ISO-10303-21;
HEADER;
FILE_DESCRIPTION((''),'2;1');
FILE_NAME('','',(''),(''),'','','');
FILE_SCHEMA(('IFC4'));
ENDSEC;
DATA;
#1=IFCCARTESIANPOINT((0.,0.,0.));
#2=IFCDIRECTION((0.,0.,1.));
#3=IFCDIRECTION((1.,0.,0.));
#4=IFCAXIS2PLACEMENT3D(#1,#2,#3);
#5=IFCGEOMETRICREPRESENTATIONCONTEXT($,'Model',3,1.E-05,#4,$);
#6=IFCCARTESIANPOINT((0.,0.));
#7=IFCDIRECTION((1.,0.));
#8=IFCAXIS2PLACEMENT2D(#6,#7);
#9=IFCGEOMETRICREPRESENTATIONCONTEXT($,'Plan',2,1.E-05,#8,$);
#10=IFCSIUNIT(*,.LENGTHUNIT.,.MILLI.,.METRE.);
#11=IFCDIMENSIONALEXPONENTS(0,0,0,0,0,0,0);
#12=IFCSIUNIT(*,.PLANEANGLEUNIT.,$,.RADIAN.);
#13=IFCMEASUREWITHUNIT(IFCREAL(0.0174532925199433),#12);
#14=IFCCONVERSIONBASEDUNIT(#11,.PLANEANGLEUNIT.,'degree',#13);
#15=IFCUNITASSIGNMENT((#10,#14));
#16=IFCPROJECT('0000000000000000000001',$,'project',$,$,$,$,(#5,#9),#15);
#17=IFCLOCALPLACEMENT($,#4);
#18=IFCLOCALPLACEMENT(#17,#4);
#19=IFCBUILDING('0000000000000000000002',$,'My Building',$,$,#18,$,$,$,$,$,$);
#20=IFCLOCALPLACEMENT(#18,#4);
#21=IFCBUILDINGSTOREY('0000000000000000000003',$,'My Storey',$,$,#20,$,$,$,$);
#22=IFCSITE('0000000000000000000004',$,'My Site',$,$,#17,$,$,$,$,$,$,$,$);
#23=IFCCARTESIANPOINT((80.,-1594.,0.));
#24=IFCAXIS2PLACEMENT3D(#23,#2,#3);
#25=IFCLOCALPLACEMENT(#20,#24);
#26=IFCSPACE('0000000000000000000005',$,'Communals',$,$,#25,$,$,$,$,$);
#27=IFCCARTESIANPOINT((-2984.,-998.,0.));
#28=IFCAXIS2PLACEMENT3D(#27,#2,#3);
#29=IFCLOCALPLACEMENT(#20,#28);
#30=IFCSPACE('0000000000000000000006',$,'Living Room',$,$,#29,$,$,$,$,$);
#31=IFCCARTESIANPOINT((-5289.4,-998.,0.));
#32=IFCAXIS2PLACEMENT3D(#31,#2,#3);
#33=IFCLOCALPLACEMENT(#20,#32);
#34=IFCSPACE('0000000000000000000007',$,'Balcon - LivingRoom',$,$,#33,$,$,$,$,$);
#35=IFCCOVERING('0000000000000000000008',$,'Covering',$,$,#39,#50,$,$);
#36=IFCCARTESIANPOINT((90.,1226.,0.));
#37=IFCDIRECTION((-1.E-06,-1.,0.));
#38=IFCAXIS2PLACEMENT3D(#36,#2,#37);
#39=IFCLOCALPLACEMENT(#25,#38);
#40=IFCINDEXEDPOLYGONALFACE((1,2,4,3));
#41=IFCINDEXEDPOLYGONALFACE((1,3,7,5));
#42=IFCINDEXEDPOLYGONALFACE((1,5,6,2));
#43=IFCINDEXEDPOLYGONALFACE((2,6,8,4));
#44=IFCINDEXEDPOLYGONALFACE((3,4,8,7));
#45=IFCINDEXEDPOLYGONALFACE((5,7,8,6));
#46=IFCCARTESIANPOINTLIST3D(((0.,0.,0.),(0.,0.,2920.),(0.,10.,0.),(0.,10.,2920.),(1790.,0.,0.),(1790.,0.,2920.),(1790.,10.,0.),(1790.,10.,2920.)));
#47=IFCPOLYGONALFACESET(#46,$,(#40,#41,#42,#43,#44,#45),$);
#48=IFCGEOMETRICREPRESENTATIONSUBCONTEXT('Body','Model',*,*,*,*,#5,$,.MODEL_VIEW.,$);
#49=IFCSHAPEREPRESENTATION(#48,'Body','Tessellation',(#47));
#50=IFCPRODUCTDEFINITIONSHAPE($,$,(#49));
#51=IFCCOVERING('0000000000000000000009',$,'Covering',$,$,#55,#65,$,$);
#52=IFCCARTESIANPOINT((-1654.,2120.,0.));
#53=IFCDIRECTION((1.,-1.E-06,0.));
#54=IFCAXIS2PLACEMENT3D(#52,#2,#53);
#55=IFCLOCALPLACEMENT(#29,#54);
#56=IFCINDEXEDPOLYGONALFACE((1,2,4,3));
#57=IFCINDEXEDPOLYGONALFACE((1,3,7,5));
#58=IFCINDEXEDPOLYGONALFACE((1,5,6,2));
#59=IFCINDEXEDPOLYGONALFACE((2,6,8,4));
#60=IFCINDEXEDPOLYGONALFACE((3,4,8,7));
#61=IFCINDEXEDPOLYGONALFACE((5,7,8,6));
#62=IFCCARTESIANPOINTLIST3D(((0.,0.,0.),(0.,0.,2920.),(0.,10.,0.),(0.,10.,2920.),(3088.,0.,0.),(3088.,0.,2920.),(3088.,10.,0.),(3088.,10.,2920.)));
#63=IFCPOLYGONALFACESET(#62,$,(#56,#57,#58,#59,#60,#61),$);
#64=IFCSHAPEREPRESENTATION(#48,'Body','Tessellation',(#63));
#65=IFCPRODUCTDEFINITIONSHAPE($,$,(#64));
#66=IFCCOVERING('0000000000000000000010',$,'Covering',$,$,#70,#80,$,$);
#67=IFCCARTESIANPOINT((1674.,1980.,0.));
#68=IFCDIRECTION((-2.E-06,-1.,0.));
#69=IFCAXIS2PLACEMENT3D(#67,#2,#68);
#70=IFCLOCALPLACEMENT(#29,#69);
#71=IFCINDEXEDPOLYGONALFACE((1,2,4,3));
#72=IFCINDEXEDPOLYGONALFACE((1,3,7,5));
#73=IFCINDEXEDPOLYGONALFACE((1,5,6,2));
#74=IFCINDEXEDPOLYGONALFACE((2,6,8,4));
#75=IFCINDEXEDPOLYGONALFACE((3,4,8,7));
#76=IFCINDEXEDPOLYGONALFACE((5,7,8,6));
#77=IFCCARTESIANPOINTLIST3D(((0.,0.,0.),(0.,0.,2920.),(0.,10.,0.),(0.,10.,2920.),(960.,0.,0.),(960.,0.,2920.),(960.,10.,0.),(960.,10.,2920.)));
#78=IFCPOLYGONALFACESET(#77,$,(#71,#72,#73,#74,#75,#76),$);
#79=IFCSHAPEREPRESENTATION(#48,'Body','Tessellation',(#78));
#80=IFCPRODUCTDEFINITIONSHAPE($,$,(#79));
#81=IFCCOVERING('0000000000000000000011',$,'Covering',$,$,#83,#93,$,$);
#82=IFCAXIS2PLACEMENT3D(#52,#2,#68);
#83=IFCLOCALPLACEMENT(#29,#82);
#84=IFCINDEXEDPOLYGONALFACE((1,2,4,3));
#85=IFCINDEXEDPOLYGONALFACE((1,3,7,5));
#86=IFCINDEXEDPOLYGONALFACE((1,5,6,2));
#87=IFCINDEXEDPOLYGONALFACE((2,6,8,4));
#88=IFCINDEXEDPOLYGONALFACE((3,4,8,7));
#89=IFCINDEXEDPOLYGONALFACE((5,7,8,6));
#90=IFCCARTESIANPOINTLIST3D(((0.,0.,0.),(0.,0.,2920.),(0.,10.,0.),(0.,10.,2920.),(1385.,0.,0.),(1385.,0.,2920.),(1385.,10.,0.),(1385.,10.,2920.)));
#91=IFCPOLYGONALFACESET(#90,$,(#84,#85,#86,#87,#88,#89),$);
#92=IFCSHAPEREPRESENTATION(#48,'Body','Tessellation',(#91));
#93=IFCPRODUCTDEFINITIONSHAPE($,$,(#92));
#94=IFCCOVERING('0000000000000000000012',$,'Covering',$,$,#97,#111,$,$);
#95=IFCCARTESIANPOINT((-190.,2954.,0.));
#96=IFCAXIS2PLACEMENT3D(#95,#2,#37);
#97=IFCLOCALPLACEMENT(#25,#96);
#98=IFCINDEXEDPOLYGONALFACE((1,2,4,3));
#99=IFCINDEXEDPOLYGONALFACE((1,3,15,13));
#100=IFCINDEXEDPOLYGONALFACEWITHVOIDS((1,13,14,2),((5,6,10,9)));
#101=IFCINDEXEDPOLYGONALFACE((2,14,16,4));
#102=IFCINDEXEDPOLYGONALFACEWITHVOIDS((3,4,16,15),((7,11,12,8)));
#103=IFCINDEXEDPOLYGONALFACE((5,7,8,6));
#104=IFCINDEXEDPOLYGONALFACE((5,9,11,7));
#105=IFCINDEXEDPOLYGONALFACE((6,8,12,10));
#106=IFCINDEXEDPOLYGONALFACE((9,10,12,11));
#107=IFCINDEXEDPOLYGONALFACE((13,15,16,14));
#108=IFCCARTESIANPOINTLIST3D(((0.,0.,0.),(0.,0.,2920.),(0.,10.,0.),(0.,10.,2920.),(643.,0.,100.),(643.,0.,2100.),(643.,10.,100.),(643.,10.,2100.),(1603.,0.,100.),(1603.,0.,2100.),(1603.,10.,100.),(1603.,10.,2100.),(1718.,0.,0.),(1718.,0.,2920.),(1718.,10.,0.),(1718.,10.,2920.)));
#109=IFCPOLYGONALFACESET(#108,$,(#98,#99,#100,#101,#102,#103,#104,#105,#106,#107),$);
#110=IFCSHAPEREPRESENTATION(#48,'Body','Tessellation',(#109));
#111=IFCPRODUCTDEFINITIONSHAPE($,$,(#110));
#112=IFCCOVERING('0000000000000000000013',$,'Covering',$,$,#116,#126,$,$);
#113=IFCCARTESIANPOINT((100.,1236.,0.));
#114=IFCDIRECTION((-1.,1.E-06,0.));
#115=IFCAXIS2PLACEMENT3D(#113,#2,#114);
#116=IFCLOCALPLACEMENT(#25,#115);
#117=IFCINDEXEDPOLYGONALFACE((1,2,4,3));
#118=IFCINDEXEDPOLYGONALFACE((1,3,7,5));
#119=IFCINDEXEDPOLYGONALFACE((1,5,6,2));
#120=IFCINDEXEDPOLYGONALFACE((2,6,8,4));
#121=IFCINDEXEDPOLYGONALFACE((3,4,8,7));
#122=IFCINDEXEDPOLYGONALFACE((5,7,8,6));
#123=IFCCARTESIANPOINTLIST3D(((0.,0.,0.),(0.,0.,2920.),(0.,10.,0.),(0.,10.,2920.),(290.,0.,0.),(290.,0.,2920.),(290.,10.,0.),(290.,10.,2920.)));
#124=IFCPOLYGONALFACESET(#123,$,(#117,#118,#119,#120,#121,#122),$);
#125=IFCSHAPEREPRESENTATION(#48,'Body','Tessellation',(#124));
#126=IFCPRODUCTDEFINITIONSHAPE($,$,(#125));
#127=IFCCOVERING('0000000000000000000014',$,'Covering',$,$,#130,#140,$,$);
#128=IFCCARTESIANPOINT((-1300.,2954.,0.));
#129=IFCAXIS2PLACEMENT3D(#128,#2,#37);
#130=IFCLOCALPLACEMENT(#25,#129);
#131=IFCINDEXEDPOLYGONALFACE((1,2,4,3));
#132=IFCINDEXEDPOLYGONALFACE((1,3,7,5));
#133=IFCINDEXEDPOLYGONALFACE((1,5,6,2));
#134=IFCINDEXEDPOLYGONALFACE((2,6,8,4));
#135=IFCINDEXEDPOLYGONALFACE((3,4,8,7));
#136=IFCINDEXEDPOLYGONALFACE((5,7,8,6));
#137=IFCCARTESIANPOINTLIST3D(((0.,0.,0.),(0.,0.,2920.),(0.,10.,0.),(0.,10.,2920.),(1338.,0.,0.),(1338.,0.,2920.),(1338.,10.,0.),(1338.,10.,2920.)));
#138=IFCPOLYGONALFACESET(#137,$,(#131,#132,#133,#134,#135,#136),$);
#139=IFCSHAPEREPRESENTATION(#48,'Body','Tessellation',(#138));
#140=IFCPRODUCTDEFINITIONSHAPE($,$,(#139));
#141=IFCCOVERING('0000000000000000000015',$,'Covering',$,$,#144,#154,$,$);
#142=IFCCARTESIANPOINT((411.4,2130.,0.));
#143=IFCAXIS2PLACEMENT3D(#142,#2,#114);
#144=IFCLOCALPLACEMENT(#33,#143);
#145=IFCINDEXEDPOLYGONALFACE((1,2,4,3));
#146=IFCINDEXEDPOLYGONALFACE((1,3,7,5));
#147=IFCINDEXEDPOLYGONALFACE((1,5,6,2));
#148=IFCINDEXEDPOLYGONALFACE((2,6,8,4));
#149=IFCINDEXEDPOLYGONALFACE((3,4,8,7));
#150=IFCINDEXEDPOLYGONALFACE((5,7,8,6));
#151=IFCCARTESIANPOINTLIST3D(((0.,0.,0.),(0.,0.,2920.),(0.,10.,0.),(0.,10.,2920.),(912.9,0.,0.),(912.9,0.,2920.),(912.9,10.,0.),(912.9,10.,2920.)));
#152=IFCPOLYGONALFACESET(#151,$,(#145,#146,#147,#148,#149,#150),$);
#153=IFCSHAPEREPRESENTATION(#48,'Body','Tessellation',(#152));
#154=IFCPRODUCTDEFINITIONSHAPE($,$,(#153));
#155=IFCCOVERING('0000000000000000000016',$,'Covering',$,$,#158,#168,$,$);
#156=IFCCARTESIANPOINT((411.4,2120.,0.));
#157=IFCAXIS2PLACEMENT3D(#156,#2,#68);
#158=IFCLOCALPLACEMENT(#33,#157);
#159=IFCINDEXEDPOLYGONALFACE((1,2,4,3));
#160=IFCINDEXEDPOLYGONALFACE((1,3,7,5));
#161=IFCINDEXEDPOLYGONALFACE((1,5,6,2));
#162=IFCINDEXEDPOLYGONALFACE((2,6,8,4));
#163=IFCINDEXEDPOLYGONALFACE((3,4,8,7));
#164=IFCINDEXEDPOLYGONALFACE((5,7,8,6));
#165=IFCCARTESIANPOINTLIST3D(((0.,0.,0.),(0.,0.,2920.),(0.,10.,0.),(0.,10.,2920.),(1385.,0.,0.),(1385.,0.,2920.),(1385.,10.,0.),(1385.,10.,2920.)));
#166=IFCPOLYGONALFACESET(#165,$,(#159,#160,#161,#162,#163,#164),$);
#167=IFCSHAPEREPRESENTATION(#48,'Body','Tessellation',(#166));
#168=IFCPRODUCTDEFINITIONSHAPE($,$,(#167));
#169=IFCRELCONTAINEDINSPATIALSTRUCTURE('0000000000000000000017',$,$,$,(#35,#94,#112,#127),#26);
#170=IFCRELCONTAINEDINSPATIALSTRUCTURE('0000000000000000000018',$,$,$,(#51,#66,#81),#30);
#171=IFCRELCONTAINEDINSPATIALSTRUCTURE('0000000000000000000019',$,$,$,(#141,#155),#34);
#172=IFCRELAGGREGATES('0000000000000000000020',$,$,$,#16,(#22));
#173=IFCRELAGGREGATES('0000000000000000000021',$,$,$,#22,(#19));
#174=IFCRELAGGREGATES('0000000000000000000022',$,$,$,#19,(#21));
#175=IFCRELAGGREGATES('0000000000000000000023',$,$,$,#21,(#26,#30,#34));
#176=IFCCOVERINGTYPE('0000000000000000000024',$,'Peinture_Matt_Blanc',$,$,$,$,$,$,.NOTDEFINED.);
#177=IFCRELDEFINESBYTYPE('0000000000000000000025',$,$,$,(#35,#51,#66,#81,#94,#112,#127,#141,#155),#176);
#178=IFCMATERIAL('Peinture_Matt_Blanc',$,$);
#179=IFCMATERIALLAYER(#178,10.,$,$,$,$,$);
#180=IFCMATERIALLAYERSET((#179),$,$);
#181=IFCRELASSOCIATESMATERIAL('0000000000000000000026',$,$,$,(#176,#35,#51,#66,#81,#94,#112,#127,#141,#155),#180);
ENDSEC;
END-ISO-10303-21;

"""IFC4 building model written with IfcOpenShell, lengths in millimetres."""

from ifc_helpers import new_model, entity, si_unit, converted_unit, frame, origin_with_axes, origin_2d_with_axis, place, context, subcontext, project, spatial, line, indexed_curve, outline, extrude, clip, halfspace, source, transform, mapped, material, layer, layer_set, layer_usage, type_object, element, save


model = new_model("IFC4")

# Units and contexts
model_context = context("Model", 3, precision=1e-05, world=origin_with_axes())
plan_context = context("Plan", 2, precision=1e-05, world=origin_2d_with_axis())
body_context_1 = subcontext(model_context, "Body", "Model", "MODEL_VIEW")
ifc_project = project(units=[si_unit("LENGTHUNIT", "METRE", prefix="MILLI"), converted_unit("PLANEANGLEUNIT", "degree", entity("IfcReal", 0.0174532925199433), si_unit("PLANEANGLEUNIT", "RADIAN"), dimensions=[0, 0, 0, 0, 0, 0, 0])], contexts=[model_context, plan_context])

# Site, building, storey
site_placement = place(None, origin_with_axes())
site = spatial("IfcSite", under=ifc_project, at=site_placement, Name="My Site")
building_placement = place(site_placement, origin_with_axes())
building = spatial("IfcBuilding", under=site, at=building_placement, Name="My Building")
storey_placement = place(building_placement, origin_with_axes())
storey = spatial("IfcBuildingStorey", under=building, at=storey_placement, Name="My Storey")

# Shared definitions
shared_shape_1 = source(origin_with_axes(), body_context_1, "Body", "SweptSolid", [
    extrude(outline(indexed_curve([(0.0, 0.0), (960.0, 0.0), (960.0, 2000.0), (0.0, 2000.0)], segments=[line(1, 2, 3, 4, 1)])), frame((0.0, -100.0, 0.0), z_axis=(0.0, -1.0, 0.0), x_axis=(1.0, 0.0, 0.0)), (0.0, 0.0, -1.0), 280.0),
])

# Shared definitions
space_1_placement = place(storey_placement, frame((80.0, -1594.0, 0.0), z_axis=(0.0, 0.0, 1.0), x_axis=(1.0, 0.0, 0.0)))
space_1 = spatial("IfcSpace", under=storey, at=space_1_placement, Name="Communals")

# Covering
ifc_material_1 = material(Name="Peinture_Matt_Blanc")
ifc_layer_1 = layer(ifc_material_1, 10.0)
ifc_layer_set_1 = layer_set([ifc_layer_1])
ifc_layer_usage_1 = layer_usage(ifc_layer_set_1, "AXIS2", "POSITIVE", 0.0)
covering_type_1 = type_object("IfcCoveringType", Name="Peinture_Matt_Blanc", PredefinedType="NOTDEFINED", material=ifc_layer_set_1)
covering_1_placement = place(space_1_placement, frame((90.0, 1226.0, 0.0), z_axis=(0.0, 0.0, 1.0), x_axis=(-0.000001, -1.0, 0.0)))
element("IfcCovering", 1, at=covering_1_placement, inside=space_1, type_object=covering_type_1, material=ifc_layer_usage_1, Name="Covering", context=body_context_1, shape_type="Clipping", body=[
    clip(extrude(outline(indexed_curve([(0.0, 0.0), (0.0, 10.0), (1790.0, 10.0), (1790.0, 0.0), (0.0, 0.0)], self_intersect=False)), origin_with_axes(), (0.0, 0.0, 1.0), 2920.0), halfspace(frame((0.0, 0.0, 2920.0), z_axis=(0.0, 0.0, 1.0), x_axis=(-1.0, 0.0, 0.0)), False)),
])

# Shared definitions
space_2_placement = place(storey_placement, frame((-2984.0, -998.0, 0.0), z_axis=(0.0, 0.0, 1.0), x_axis=(1.0, 0.0, 0.0)))
space_2 = spatial("IfcSpace", under=storey, at=space_2_placement, Name="Living Room")

# Coverings
ifc_layer_usage_2 = layer_usage(ifc_layer_set_1, "AXIS2", "POSITIVE", 0.0)
covering_2_placement = place(space_2_placement, frame((-1654.0, 2120.0, 0.0), z_axis=(0.0, 0.0, 1.0), x_axis=(1.0, -0.000001, 0.0)))
element("IfcCovering", 2, at=covering_2_placement, inside=space_2, type_object=covering_type_1, material=ifc_layer_usage_2, Name="Covering", context=body_context_1, shape_type="Clipping", body=[
    clip(clip(extrude(outline(indexed_curve([(0.0, 0.0), (0.0, 10.0), (3088.0, 10.0), (3088.0, 0.0), (0.0, 0.0)], self_intersect=False)), origin_with_axes(), (0.0, 0.0, 1.0), 2920.0), halfspace(frame((0.0, 0.0, 2920.0), z_axis=(0.0, 0.0, 1.0), x_axis=(-1.0, 0.0, 0.0)), False)), halfspace(frame((0.0, 0.0, 2920.0), z_axis=(0.0, 0.0, 1.0), x_axis=(-1.0, 0.0, 0.0)), False)),
])
ifc_layer_usage_3 = layer_usage(ifc_layer_set_1, "AXIS2", "POSITIVE", 0.0)
covering_3_placement = place(space_2_placement, frame((1674.0, 1980.0, 0.0), z_axis=(0.0, 0.0, 1.0), x_axis=(-0.000002, -1.0, 0.0)))
element("IfcCovering", 3, at=covering_3_placement, inside=space_2, type_object=covering_type_1, material=ifc_layer_usage_3, Name="Covering", context=body_context_1, shape_type="Clipping", body=[
    clip(clip(extrude(outline(indexed_curve([(0.0, 0.0), (0.0, 10.0), (960.0, 10.0), (960.0, 0.0), (0.0, 0.0)], self_intersect=False)), origin_with_axes(), (0.0, 0.0, 1.0), 2920.0), halfspace(frame((0.0, 0.0, 2920.0), z_axis=(0.0, 0.0, 1.0), x_axis=(-1.0, 0.0, 0.0)), False)), halfspace(frame((0.0, 0.0, 2920.0), z_axis=(0.0, 0.0, 1.0), x_axis=(-1.0, 0.0, 0.0)), False)),
])
ifc_layer_usage_4 = layer_usage(ifc_layer_set_1, "AXIS2", "POSITIVE", 0.0)
covering_4_placement = place(space_2_placement, frame((-1654.0, 2120.0, 0.0), z_axis=(0.0, 0.0, 1.0), x_axis=(-0.000002, -1.0, 0.0)))
element("IfcCovering", 4, at=covering_4_placement, inside=space_2, type_object=covering_type_1, material=ifc_layer_usage_4, Name="Covering", context=body_context_1, shape_type="Clipping", body=[
    clip(extrude(outline(indexed_curve([(0.0, 0.0), (0.0, 10.0), (1385.0, 10.0), (1385.0, 0.0), (0.0, 0.0)], self_intersect=False)), origin_with_axes(), (0.0, 0.0, 1.0), 2920.0), halfspace(frame((0.0, 0.0, 2920.0), z_axis=(0.0, 0.0, 1.0), x_axis=(-1.0, 0.0, 0.0)), False)),
])

# Covering, opening
ifc_layer_usage_5 = layer_usage(ifc_layer_set_1, "AXIS2", "POSITIVE", 0.0)
covering_5_placement = place(space_1_placement, frame((-190.0, 2954.0, 0.0), z_axis=(0.0, 0.0, 1.0), x_axis=(-0.000001, -1.0, 0.0)))
covering_5 = element("IfcCovering", 5, at=covering_5_placement, inside=space_1, type_object=covering_type_1, material=ifc_layer_usage_5, Name="Covering", context=body_context_1, shape_type="Clipping", body=[
    clip(extrude(outline(indexed_curve([(0.0, 0.0), (0.0, 10.0), (1718.0, 10.0), (1718.0, 0.0), (0.0, 0.0)], self_intersect=False)), origin_with_axes(), (0.0, 0.0, 1.0), 2920.0), halfspace(frame((0.0, 0.0, 2920.0), z_axis=(0.0, 0.0, 1.0), x_axis=(-1.0, 0.0, 0.0)), False)),
])
opening_1_placement = place(covering_5_placement, frame((1603.0, 90.0, 100.0), z_axis=(0.0, 0.0, 1.0), x_axis=(-1.0, 0.0, 0.0)))
element("IfcOpeningElement", 6, at=opening_1_placement, cuts=covering_5, PredefinedType="OPENING", context=body_context_1, shape_type="MappedRepresentation", body=[
    mapped(shared_shape_1, transform((0.0, 0.0, 0.0), x_axis=(1.0, 0.0, 0.0), y_axis=(0.0, 1.0, 0.0), z_axis=(0.0, 0.0, 1.0), scale=1.0)),
])

# Coverings
ifc_layer_usage_6 = layer_usage(ifc_layer_set_1, "AXIS2", "POSITIVE", 0.0)
covering_6_placement = place(space_1_placement, frame((100.0, 1236.0, 0.0), z_axis=(0.0, 0.0, 1.0), x_axis=(-1.0, 0.000001, 0.0)))
element("IfcCovering", 7, at=covering_6_placement, inside=space_1, type_object=covering_type_1, material=ifc_layer_usage_6, Name="Covering", context=body_context_1, shape_type="Clipping", body=[
    clip(extrude(outline(indexed_curve([(0.0, 0.0), (0.0, 10.0), (290.0, 10.0), (290.0, 0.0), (0.0, 0.0)], self_intersect=False)), origin_with_axes(), (0.0, 0.0, 1.0), 2920.0), halfspace(frame((0.0, 0.0, 2920.0), z_axis=(0.0, 0.0, 1.0), x_axis=(-1.0, 0.0, 0.0)), False)),
])
ifc_layer_usage_7 = layer_usage(ifc_layer_set_1, "AXIS2", "POSITIVE", 0.0)
covering_7_placement = place(space_1_placement, frame((-1300.0, 2954.0, 0.0), z_axis=(0.0, 0.0, 1.0), x_axis=(-0.000001, -1.0, 0.0)))
element("IfcCovering", 8, at=covering_7_placement, inside=space_1, type_object=covering_type_1, material=ifc_layer_usage_7, Name="Covering", context=body_context_1, shape_type="Clipping", body=[
    clip(extrude(outline(indexed_curve([(0.0, 0.0), (0.0, 10.0), (1338.0, 10.0), (1338.0, 0.0), (0.0, 0.0)], self_intersect=False)), origin_with_axes(), (0.0, 0.0, 1.0), 2920.0), halfspace(frame((0.0, 0.0, 2920.0), z_axis=(0.0, 0.0, 1.0), x_axis=(-1.0, 0.0, 0.0)), False)),
])

# Shared definitions
space_3_placement = place(storey_placement, frame((-5289.4, -998.0, 0.0), z_axis=(0.0, 0.0, 1.0), x_axis=(1.0, 0.0, 0.0)))
space_3 = spatial("IfcSpace", under=storey, at=space_3_placement, Name="Balcon - LivingRoom")

# Coverings
ifc_layer_usage_8 = layer_usage(ifc_layer_set_1, "AXIS2", "POSITIVE", 0.0)
covering_8_placement = place(space_3_placement, frame((411.4, 2130.0, 0.0), z_axis=(0.0, 0.0, 1.0), x_axis=(-1.0, 0.000001, 0.0)))
element("IfcCovering", 9, at=covering_8_placement, inside=space_3, type_object=covering_type_1, material=ifc_layer_usage_8, Name="Covering", context=body_context_1, shape_type="Clipping", body=[
    clip(extrude(outline(indexed_curve([(0.0, 0.0), (0.0, 10.0), (912.9, 10.0), (912.9, 0.0), (0.0, 0.0)], self_intersect=False)), origin_with_axes(), (0.0, 0.0, 1.0), 2920.0), halfspace(frame((0.0, 0.0, 2920.0), z_axis=(0.0, 0.0, 1.0), x_axis=(-1.0, 0.0, 0.0)), False)),
])
ifc_layer_usage_9 = layer_usage(ifc_layer_set_1, "AXIS2", "POSITIVE", 0.0)
covering_9_placement = place(space_3_placement, frame((411.4, 2120.0, 0.0), z_axis=(0.0, 0.0, 1.0), x_axis=(-0.000002, -1.0, 0.0)))
element("IfcCovering", 10, at=covering_9_placement, inside=space_3, type_object=covering_type_1, material=ifc_layer_usage_9, Name="Covering", context=body_context_1, shape_type="Clipping", body=[
    clip(extrude(outline(indexed_curve([(0.0, 0.0), (0.0, 10.0), (1385.0, 10.0), (1385.0, 0.0), (0.0, 0.0)], self_intersect=False)), origin_with_axes(), (0.0, 0.0, 1.0), 2920.0), halfspace(frame((0.0, 0.0, 2920.0), z_axis=(0.0, 0.0, 1.0), x_axis=(-1.0, 0.0, 0.0)), False)),
])

save(model, "model.ifc")
